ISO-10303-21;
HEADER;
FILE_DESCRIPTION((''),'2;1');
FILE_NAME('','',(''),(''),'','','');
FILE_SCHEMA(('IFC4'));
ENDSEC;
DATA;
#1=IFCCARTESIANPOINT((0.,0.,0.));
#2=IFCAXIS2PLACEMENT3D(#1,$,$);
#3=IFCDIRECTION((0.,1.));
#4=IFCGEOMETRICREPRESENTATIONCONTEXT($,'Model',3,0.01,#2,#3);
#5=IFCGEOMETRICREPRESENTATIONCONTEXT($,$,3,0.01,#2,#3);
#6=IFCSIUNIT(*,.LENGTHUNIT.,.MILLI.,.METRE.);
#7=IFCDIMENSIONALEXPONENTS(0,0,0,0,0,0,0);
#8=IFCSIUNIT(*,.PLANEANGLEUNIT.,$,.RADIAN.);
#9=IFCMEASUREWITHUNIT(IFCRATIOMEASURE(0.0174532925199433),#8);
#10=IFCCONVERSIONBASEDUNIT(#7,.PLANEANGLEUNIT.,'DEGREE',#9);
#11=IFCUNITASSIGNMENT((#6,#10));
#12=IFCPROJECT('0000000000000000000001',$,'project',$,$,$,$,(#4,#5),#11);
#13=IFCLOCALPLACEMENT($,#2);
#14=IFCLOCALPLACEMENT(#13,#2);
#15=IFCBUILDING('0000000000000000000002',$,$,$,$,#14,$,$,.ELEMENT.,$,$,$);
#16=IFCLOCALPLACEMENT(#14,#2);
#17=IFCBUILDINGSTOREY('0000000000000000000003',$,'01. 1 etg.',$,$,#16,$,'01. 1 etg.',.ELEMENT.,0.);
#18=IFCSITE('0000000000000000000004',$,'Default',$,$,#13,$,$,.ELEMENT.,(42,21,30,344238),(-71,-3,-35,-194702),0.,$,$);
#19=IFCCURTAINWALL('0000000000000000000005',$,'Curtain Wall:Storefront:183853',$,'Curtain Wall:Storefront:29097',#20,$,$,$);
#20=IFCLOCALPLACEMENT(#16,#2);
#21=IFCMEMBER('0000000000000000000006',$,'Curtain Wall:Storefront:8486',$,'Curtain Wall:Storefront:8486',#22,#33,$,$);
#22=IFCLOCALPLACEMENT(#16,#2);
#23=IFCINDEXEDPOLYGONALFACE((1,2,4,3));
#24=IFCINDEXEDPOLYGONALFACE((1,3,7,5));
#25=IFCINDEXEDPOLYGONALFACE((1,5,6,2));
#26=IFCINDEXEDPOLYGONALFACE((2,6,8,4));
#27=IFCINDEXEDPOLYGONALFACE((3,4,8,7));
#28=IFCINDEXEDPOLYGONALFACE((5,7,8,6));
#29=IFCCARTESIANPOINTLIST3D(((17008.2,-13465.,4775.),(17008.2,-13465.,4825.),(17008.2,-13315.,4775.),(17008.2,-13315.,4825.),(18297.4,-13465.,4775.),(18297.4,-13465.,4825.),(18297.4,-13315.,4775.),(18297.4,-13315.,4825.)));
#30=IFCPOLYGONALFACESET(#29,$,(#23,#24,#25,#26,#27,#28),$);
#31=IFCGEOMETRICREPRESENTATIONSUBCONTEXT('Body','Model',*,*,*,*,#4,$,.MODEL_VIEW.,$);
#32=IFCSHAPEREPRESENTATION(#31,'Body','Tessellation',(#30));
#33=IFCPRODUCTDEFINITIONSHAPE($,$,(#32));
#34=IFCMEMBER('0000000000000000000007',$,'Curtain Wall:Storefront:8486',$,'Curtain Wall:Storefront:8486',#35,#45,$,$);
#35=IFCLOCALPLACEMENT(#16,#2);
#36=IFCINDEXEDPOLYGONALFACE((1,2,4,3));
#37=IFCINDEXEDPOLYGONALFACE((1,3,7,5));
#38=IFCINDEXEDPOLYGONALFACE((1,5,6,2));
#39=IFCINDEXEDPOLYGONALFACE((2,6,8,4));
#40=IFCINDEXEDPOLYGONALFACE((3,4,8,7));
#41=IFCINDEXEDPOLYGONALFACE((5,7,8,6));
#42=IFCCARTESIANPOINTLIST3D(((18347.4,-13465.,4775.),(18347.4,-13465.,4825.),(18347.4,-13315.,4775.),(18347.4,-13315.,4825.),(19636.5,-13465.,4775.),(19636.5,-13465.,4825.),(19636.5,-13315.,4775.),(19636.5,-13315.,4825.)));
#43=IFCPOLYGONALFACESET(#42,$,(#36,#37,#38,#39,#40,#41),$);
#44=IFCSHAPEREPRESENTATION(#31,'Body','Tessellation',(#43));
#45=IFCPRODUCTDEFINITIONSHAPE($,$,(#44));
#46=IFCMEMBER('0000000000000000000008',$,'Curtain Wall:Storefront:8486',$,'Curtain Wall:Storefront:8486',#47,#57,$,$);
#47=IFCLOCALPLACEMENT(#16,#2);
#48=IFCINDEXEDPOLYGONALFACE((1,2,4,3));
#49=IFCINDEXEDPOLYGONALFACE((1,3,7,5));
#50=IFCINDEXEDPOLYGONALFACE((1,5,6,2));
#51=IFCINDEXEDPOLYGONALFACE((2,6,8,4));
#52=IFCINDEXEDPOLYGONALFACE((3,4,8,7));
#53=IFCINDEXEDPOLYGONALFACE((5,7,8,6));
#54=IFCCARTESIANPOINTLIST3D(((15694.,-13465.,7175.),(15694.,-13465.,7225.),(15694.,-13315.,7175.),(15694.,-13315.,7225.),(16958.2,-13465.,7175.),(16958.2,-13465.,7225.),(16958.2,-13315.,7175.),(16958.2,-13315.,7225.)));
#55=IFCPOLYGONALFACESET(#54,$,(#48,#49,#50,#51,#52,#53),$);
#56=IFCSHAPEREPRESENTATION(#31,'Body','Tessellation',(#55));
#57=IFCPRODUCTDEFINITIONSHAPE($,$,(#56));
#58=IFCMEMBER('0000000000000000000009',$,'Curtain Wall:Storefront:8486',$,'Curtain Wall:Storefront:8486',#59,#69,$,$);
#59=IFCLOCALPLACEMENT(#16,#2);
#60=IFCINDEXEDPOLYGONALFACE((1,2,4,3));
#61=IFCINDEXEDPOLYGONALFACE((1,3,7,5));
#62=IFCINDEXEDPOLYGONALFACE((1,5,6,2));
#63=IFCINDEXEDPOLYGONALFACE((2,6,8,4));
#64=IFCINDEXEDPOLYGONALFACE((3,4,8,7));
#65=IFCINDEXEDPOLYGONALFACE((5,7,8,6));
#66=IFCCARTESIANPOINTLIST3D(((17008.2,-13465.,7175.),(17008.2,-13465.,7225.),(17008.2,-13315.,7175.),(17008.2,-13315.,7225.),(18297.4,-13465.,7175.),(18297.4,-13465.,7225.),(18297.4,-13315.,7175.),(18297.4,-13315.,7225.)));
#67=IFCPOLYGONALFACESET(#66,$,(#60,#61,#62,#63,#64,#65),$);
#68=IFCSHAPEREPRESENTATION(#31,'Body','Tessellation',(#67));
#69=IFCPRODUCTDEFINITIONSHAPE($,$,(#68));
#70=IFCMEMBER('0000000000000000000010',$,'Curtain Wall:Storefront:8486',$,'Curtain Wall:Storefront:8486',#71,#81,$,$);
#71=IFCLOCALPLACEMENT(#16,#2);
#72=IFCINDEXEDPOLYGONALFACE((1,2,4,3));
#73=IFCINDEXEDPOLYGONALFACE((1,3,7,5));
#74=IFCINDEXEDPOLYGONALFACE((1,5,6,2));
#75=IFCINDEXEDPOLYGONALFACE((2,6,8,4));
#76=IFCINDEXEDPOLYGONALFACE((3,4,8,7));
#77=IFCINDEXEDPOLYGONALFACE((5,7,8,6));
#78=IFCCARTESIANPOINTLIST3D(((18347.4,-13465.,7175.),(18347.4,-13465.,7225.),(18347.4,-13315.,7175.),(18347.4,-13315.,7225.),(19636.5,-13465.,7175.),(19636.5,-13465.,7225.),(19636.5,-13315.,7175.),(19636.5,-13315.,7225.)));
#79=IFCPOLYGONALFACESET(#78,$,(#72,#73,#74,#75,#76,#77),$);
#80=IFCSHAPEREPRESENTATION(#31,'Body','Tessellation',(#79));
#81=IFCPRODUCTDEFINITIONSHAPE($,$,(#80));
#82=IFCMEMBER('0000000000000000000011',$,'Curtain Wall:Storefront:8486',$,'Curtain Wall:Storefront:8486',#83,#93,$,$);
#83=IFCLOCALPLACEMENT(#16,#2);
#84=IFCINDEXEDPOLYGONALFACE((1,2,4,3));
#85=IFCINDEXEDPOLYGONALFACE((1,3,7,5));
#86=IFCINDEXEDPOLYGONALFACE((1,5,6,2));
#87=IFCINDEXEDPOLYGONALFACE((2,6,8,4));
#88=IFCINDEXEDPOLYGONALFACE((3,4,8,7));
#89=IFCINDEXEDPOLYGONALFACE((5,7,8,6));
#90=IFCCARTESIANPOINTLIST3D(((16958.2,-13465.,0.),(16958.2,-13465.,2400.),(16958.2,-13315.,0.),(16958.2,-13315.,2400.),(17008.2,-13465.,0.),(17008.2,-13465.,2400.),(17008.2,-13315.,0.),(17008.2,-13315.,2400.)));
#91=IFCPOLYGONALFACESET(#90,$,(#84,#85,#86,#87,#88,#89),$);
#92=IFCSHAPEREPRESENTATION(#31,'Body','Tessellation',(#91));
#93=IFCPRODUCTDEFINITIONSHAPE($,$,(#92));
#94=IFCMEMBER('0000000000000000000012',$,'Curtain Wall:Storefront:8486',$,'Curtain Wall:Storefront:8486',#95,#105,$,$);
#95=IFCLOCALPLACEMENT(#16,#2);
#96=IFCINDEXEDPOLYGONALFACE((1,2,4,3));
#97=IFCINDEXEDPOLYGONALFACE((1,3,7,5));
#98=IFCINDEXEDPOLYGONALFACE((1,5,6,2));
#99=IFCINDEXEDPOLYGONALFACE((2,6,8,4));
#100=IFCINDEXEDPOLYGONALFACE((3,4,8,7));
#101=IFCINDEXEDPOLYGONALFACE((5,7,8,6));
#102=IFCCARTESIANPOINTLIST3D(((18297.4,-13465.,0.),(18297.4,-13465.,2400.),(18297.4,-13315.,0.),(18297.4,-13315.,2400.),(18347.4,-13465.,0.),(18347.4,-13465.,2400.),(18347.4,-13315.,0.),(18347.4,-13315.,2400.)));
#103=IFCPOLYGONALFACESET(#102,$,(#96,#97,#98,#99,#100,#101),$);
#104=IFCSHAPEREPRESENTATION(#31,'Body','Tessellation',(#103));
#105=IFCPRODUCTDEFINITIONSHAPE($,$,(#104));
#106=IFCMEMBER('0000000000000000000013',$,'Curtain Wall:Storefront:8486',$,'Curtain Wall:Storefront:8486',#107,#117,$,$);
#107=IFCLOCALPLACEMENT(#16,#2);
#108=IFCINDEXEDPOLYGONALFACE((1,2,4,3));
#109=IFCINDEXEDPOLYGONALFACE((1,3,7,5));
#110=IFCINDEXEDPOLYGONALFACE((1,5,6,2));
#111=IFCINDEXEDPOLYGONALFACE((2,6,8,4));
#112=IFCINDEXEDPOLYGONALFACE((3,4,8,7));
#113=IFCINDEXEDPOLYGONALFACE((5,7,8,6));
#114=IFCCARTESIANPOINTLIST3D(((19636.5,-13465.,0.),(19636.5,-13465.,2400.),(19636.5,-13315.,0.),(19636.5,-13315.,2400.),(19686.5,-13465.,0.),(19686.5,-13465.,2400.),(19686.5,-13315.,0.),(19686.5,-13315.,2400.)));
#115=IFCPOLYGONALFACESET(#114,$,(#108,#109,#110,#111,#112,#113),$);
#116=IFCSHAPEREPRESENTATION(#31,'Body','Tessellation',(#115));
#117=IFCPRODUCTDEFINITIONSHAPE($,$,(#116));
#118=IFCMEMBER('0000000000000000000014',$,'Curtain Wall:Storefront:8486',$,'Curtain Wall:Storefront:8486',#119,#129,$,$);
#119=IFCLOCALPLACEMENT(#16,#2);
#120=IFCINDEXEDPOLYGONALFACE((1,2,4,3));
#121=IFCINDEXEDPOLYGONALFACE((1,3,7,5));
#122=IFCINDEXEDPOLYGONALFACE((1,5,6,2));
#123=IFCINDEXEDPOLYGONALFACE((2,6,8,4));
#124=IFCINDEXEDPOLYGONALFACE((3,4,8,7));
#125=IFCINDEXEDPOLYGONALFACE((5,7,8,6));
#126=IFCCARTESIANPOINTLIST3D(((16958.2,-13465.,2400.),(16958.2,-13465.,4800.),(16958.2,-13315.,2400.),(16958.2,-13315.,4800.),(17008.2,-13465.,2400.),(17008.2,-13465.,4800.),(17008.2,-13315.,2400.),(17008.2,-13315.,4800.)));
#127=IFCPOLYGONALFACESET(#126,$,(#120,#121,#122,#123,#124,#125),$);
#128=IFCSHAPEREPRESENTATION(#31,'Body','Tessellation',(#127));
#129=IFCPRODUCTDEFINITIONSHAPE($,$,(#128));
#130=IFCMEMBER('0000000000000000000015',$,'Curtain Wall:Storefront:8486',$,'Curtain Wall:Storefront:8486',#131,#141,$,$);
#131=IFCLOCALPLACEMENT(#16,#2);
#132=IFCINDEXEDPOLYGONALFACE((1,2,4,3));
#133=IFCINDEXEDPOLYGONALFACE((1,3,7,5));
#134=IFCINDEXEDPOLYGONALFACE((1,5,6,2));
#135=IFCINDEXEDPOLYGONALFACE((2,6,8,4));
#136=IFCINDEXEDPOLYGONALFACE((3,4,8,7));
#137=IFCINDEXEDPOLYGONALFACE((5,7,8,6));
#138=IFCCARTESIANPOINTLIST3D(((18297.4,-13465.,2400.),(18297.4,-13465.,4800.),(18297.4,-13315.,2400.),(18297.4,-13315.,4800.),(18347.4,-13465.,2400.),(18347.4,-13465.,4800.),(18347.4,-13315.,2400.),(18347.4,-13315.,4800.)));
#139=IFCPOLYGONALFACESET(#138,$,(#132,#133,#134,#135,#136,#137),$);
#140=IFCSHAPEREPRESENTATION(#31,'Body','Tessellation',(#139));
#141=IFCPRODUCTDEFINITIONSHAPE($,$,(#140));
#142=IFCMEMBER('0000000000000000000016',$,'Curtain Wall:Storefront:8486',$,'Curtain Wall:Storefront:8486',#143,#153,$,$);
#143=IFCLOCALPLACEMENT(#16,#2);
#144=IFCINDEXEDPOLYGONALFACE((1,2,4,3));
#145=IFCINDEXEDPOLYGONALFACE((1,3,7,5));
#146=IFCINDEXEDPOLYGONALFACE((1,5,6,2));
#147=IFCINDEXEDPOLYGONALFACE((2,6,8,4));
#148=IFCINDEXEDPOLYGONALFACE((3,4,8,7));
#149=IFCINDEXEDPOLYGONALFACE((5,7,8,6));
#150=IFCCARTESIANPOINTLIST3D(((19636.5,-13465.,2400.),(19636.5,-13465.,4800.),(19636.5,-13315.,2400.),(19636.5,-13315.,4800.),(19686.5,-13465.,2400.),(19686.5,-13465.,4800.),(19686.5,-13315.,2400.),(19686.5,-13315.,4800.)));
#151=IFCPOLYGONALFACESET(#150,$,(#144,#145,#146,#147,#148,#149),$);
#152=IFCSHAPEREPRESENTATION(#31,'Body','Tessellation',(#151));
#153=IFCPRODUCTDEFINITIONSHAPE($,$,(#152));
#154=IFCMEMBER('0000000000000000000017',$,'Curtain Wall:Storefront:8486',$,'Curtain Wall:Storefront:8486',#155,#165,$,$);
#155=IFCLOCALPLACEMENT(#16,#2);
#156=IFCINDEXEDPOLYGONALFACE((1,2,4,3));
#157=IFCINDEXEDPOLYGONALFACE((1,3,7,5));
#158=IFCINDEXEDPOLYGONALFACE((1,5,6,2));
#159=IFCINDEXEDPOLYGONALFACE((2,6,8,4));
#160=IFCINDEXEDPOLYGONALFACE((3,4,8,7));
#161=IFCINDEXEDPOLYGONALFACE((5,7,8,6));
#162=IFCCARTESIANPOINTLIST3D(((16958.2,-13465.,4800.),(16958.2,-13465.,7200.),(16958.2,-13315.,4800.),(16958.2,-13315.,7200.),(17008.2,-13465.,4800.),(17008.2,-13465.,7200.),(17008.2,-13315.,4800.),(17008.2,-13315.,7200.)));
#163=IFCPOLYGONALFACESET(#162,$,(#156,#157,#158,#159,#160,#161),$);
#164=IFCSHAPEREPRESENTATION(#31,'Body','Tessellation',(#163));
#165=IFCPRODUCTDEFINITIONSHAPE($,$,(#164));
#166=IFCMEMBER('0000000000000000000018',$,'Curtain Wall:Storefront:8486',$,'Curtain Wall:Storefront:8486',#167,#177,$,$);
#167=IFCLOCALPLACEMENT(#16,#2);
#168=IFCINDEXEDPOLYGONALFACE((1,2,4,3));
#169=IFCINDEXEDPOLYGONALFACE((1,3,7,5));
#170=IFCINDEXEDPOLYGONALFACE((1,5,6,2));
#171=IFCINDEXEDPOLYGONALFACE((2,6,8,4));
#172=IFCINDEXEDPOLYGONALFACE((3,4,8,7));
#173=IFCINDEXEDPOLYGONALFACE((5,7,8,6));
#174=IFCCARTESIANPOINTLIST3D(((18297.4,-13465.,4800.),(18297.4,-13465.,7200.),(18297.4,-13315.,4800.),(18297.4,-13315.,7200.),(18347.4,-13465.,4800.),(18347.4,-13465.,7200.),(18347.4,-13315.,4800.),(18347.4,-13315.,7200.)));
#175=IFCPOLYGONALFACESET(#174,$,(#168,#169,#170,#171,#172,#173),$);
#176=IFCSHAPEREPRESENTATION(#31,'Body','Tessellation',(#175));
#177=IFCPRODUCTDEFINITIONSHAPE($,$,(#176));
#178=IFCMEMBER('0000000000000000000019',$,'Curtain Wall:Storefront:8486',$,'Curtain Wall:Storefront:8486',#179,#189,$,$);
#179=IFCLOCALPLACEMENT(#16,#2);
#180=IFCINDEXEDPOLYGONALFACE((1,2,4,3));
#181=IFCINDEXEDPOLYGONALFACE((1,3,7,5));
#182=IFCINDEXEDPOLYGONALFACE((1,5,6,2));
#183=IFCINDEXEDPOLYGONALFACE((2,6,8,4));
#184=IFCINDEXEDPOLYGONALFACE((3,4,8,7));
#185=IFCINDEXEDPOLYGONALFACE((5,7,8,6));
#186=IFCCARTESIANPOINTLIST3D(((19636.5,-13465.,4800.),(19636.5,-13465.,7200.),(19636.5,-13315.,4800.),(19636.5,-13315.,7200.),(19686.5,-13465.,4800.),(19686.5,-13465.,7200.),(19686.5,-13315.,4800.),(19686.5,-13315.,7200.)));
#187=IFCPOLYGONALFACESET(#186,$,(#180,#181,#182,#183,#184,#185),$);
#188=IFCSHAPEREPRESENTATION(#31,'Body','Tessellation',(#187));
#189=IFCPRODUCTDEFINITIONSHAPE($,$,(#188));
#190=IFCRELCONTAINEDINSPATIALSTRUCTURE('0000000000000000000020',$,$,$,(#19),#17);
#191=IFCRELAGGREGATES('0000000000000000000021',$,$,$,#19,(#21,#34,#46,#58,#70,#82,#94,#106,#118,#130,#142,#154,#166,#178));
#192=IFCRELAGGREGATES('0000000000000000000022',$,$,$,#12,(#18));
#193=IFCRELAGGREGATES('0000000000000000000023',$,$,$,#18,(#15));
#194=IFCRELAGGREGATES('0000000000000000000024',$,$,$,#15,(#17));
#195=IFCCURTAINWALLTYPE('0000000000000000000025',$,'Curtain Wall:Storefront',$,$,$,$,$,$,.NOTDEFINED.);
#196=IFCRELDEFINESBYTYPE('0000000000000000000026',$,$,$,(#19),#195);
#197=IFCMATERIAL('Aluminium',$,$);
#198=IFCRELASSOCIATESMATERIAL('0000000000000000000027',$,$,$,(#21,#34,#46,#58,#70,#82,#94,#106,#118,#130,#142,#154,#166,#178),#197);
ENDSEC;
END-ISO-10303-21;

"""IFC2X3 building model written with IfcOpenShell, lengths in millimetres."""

from ifc_helpers import new_model, entity, si_unit, converted_unit, direction, frame, frame_2d, origin, place, context, subcontext, project, spatial, rectangle, extrude, material, type_object, element, aggregate, save


model = new_model("IFC2X3")

# Units and contexts
model_context = context("Model", 3, precision=0.01, world=origin(), true_north=direction((0.0, 1.0)))
context_of_model = context(None, 3, precision=0.01, world=origin(), true_north=direction((0.0, 1.0)))
body_context = subcontext(model_context, "Body", "Model", "MODEL_VIEW")
ifc_project = project(units=[si_unit("LENGTHUNIT", "METRE", prefix="MILLI"), converted_unit("PLANEANGLEUNIT", "DEGREE", entity("IfcRatioMeasure", 0.0174532925199433), si_unit("PLANEANGLEUNIT", "RADIAN"), dimensions=[0, 0, 0, 0, 0, 0, 0])], contexts=[model_context, context_of_model])

# Site, building, storey
site_placement = place(None, origin())
site = spatial("IfcSite", under=ifc_project, at=site_placement, Name="Default", CompositionType="ELEMENT", RefLatitude=(42, 21, 30, 344238), RefLongitude=(-71, -3, -35, -194702), RefElevation=0.0)
building_placement = place(site_placement, origin())
building = spatial("IfcBuilding", under=site, at=building_placement, CompositionType="ELEMENT")
storey_placement = place(building_placement, origin())
storey = spatial("IfcBuildingStorey", under=building, at=storey_placement, Name="01. 1 etg.", LongName="01. 1 etg.", CompositionType="ELEMENT", Elevation=0.0)

# Curtain wall, members
curtain_wall_type = type_object("IfcCurtainWallType", Name="Curtain Wall:Storefront", PredefinedType="NOTDEFINED")
curtain_wall_placement = place(storey_placement, origin())
curtain_wall = element("IfcCurtainWall", 1, at=curtain_wall_placement, inside=storey, type_object=curtain_wall_type, Name="Curtain Wall:Storefront:183853", ObjectType="Curtain Wall:Storefront:29097")
ifc_material_1 = material(Name="Aluminium")
member_1_placement = place(curtain_wall_placement, frame((17008.2, -13465.0, 4775.0)))
member_1 = element("IfcMember", 2, at=member_1_placement, material=ifc_material_1, Name="Curtain Wall:Storefront:8486", ObjectType="Curtain Wall:Storefront:8486", context=body_context, shape_type="SweptSolid", body=[
    extrude(rectangle(XDim=1289.2, YDim=150.0, at=frame_2d((0.0, 0.0), x_axis=(1.0, 0.0))), frame((644.6, 75.0, 0.0), z_axis=(0.0, 0.0, 1.0), x_axis=(-1.0, 0.0, 0.0)), (0.0, 0.0, 1.0), 50.0),
])
member_2_placement = place(curtain_wall_placement, frame((18347.4, -13465.0, 4775.0)))
member_2 = element("IfcMember", 3, at=member_2_placement, material=ifc_material_1, Name="Curtain Wall:Storefront:8486", ObjectType="Curtain Wall:Storefront:8486", context=body_context, shape_type="SweptSolid", body=[
    extrude(rectangle(XDim=1289.2, YDim=150.0, at=frame_2d((0.0, 0.0), x_axis=(1.0, 0.0))), frame((644.6, 75.0, 0.0), z_axis=(0.0, 0.0, 1.0), x_axis=(-1.0, 0.0, 0.0)), (0.0, 0.0, 1.0), 50.0),
])
member_3_placement = place(curtain_wall_placement, frame((15694.0, -13465.0, 7175.0)))
member_3 = element("IfcMember", 4, at=member_3_placement, material=ifc_material_1, Name="Curtain Wall:Storefront:8486", ObjectType="Curtain Wall:Storefront:8486", context=body_context, shape_type="SweptSolid", body=[
    extrude(rectangle(XDim=1264.2, YDim=150.0, at=frame_2d((0.0, 0.0), x_axis=(1.0, 0.0))), frame((632.1, 75.0, 0.0), z_axis=(0.0, 0.0, 1.0), x_axis=(-1.0, 0.0, 0.0)), (0.0, 0.0, 1.0), 50.0),
])
member_4_placement = place(curtain_wall_placement, frame((17008.2, -13465.0, 7175.0)))
member_4 = element("IfcMember", 5, at=member_4_placement, material=ifc_material_1, Name="Curtain Wall:Storefront:8486", ObjectType="Curtain Wall:Storefront:8486", context=body_context, shape_type="SweptSolid", body=[
    extrude(rectangle(XDim=1289.2, YDim=150.0, at=frame_2d((0.0, 0.0), x_axis=(1.0, 0.0))), frame((644.6, 75.0, 0.0), z_axis=(0.0, 0.0, 1.0), x_axis=(-1.0, 0.0, 0.0)), (0.0, 0.0, 1.0), 50.0),
])
member_5_placement = place(curtain_wall_placement, frame((18347.4, -13465.0, 7175.0)))
member_5 = element("IfcMember", 6, at=member_5_placement, material=ifc_material_1, Name="Curtain Wall:Storefront:8486", ObjectType="Curtain Wall:Storefront:8486", context=body_context, shape_type="SweptSolid", body=[
    extrude(rectangle(XDim=1289.2, YDim=150.0, at=frame_2d((0.0, 0.0), x_axis=(1.0, 0.0))), frame((644.6, 75.0, 0.0), z_axis=(0.0, 0.0, 1.0), x_axis=(-1.0, 0.0, 0.0)), (0.0, 0.0, 1.0), 50.0),
])
member_6_placement = place(curtain_wall_placement, frame((16958.2, -13465.0, 0.0)))
member_6 = element("IfcMember", 7, at=member_6_placement, material=ifc_material_1, Name="Curtain Wall:Storefront:8486", ObjectType="Curtain Wall:Storefront:8486", context=body_context, shape_type="SweptSolid", body=[
    extrude(rectangle(XDim=150.0, YDim=50.0, at=frame_2d((0.0, 0.0), x_axis=(1.0, 0.0))), frame((25.0, 75.0, 0.0), z_axis=(0.0, 0.0, 1.0), x_axis=(0.0, 1.0, 0.0)), (0.0, 0.0, 1.0), 2400.0),
])
member_7_placement = place(curtain_wall_placement, frame((18297.4, -13465.0, 0.0)))
member_7 = element("IfcMember", 8, at=member_7_placement, material=ifc_material_1, Name="Curtain Wall:Storefront:8486", ObjectType="Curtain Wall:Storefront:8486", context=body_context, shape_type="SweptSolid", body=[
    extrude(rectangle(XDim=150.0, YDim=50.0, at=frame_2d((0.0, 0.0), x_axis=(1.0, 0.0))), frame((25.0, 75.0, 0.0), z_axis=(0.0, 0.0, 1.0), x_axis=(0.0, 1.0, 0.0)), (0.0, 0.0, 1.0), 2400.0),
])
member_8_placement = place(curtain_wall_placement, frame((19636.5, -13465.0, 0.0)))
member_8 = element("IfcMember", 9, at=member_8_placement, material=ifc_material_1, Name="Curtain Wall:Storefront:8486", ObjectType="Curtain Wall:Storefront:8486", context=body_context, shape_type="SweptSolid", body=[
    extrude(rectangle(XDim=150.0, YDim=50.0, at=frame_2d((0.0, 0.0), x_axis=(1.0, 0.0))), frame((25.0, 75.0, 0.0), z_axis=(0.0, 0.0, 1.0), x_axis=(0.0, 1.0, 0.0)), (0.0, 0.0, 1.0), 2400.0),
])
member_9_placement = place(curtain_wall_placement, frame((16958.2, -13465.0, 2400.0)))
member_9 = element("IfcMember", 10, at=member_9_placement, material=ifc_material_1, Name="Curtain Wall:Storefront:8486", ObjectType="Curtain Wall:Storefront:8486", context=body_context, shape_type="SweptSolid", body=[
    extrude(rectangle(XDim=150.0, YDim=50.0, at=frame_2d((0.0, 0.0), x_axis=(1.0, 0.0))), frame((25.0, 75.0, 0.0), z_axis=(0.0, 0.0, 1.0), x_axis=(0.0, 1.0, 0.0)), (0.0, 0.0, 1.0), 2400.0),
])
member_10_placement = place(curtain_wall_placement, frame((18297.4, -13465.0, 2400.0)))
member_10 = element("IfcMember", 11, at=member_10_placement, material=ifc_material_1, Name="Curtain Wall:Storefront:8486", ObjectType="Curtain Wall:Storefront:8486", context=body_context, shape_type="SweptSolid", body=[
    extrude(rectangle(XDim=150.0, YDim=50.0, at=frame_2d((0.0, 0.0), x_axis=(1.0, 0.0))), frame((25.0, 75.0, 0.0), z_axis=(0.0, 0.0, 1.0), x_axis=(0.0, 1.0, 0.0)), (0.0, 0.0, 1.0), 2400.0),
])
member_11_placement = place(curtain_wall_placement, frame((19636.5, -13465.0, 2400.0)))
member_11 = element("IfcMember", 12, at=member_11_placement, material=ifc_material_1, Name="Curtain Wall:Storefront:8486", ObjectType="Curtain Wall:Storefront:8486", context=body_context, shape_type="SweptSolid", body=[
    extrude(rectangle(XDim=150.0, YDim=50.0, at=frame_2d((0.0, 0.0), x_axis=(1.0, 0.0))), frame((25.0, 75.0, 0.0), z_axis=(0.0, 0.0, 1.0), x_axis=(0.0, 1.0, 0.0)), (0.0, 0.0, 1.0), 2400.0),
])
member_12_placement = place(curtain_wall_placement, frame((16958.2, -13465.0, 4800.0)))
member_12 = element("IfcMember", 13, at=member_12_placement, material=ifc_material_1, Name="Curtain Wall:Storefront:8486", ObjectType="Curtain Wall:Storefront:8486", context=body_context, shape_type="SweptSolid", body=[
    extrude(rectangle(XDim=150.0, YDim=50.0, at=frame_2d((0.0, 0.0), x_axis=(1.0, 0.0))), frame((25.0, 75.0, 0.0), z_axis=(0.0, 0.0, 1.0), x_axis=(0.0, 1.0, 0.0)), (0.0, 0.0, 1.0), 2400.0),
])
member_13_placement = place(curtain_wall_placement, frame((18297.4, -13465.0, 4800.0)))
member_13 = element("IfcMember", 14, at=member_13_placement, material=ifc_material_1, Name="Curtain Wall:Storefront:8486", ObjectType="Curtain Wall:Storefront:8486", context=body_context, shape_type="SweptSolid", body=[
    extrude(rectangle(XDim=150.0, YDim=50.0, at=frame_2d((0.0, 0.0), x_axis=(1.0, 0.0))), frame((25.0, 75.0, 0.0), z_axis=(0.0, 0.0, 1.0), x_axis=(0.0, 1.0, 0.0)), (0.0, 0.0, 1.0), 2400.0),
])
member_14_placement = place(curtain_wall_placement, frame((19636.5, -13465.0, 4800.0)))
member_14 = element("IfcMember", 15, at=member_14_placement, material=ifc_material_1, Name="Curtain Wall:Storefront:8486", ObjectType="Curtain Wall:Storefront:8486", context=body_context, shape_type="SweptSolid", body=[
    extrude(rectangle(XDim=150.0, YDim=50.0, at=frame_2d((0.0, 0.0), x_axis=(1.0, 0.0))), frame((25.0, 75.0, 0.0), z_axis=(0.0, 0.0, 1.0), x_axis=(0.0, 1.0, 0.0)), (0.0, 0.0, 1.0), 2400.0),
])
aggregate(curtain_wall, [member_1, member_2, member_3, member_4, member_5, member_6, member_7, member_8, member_9, member_10, member_11, member_12, member_13, member_14])

save(model, "model.ifc")
